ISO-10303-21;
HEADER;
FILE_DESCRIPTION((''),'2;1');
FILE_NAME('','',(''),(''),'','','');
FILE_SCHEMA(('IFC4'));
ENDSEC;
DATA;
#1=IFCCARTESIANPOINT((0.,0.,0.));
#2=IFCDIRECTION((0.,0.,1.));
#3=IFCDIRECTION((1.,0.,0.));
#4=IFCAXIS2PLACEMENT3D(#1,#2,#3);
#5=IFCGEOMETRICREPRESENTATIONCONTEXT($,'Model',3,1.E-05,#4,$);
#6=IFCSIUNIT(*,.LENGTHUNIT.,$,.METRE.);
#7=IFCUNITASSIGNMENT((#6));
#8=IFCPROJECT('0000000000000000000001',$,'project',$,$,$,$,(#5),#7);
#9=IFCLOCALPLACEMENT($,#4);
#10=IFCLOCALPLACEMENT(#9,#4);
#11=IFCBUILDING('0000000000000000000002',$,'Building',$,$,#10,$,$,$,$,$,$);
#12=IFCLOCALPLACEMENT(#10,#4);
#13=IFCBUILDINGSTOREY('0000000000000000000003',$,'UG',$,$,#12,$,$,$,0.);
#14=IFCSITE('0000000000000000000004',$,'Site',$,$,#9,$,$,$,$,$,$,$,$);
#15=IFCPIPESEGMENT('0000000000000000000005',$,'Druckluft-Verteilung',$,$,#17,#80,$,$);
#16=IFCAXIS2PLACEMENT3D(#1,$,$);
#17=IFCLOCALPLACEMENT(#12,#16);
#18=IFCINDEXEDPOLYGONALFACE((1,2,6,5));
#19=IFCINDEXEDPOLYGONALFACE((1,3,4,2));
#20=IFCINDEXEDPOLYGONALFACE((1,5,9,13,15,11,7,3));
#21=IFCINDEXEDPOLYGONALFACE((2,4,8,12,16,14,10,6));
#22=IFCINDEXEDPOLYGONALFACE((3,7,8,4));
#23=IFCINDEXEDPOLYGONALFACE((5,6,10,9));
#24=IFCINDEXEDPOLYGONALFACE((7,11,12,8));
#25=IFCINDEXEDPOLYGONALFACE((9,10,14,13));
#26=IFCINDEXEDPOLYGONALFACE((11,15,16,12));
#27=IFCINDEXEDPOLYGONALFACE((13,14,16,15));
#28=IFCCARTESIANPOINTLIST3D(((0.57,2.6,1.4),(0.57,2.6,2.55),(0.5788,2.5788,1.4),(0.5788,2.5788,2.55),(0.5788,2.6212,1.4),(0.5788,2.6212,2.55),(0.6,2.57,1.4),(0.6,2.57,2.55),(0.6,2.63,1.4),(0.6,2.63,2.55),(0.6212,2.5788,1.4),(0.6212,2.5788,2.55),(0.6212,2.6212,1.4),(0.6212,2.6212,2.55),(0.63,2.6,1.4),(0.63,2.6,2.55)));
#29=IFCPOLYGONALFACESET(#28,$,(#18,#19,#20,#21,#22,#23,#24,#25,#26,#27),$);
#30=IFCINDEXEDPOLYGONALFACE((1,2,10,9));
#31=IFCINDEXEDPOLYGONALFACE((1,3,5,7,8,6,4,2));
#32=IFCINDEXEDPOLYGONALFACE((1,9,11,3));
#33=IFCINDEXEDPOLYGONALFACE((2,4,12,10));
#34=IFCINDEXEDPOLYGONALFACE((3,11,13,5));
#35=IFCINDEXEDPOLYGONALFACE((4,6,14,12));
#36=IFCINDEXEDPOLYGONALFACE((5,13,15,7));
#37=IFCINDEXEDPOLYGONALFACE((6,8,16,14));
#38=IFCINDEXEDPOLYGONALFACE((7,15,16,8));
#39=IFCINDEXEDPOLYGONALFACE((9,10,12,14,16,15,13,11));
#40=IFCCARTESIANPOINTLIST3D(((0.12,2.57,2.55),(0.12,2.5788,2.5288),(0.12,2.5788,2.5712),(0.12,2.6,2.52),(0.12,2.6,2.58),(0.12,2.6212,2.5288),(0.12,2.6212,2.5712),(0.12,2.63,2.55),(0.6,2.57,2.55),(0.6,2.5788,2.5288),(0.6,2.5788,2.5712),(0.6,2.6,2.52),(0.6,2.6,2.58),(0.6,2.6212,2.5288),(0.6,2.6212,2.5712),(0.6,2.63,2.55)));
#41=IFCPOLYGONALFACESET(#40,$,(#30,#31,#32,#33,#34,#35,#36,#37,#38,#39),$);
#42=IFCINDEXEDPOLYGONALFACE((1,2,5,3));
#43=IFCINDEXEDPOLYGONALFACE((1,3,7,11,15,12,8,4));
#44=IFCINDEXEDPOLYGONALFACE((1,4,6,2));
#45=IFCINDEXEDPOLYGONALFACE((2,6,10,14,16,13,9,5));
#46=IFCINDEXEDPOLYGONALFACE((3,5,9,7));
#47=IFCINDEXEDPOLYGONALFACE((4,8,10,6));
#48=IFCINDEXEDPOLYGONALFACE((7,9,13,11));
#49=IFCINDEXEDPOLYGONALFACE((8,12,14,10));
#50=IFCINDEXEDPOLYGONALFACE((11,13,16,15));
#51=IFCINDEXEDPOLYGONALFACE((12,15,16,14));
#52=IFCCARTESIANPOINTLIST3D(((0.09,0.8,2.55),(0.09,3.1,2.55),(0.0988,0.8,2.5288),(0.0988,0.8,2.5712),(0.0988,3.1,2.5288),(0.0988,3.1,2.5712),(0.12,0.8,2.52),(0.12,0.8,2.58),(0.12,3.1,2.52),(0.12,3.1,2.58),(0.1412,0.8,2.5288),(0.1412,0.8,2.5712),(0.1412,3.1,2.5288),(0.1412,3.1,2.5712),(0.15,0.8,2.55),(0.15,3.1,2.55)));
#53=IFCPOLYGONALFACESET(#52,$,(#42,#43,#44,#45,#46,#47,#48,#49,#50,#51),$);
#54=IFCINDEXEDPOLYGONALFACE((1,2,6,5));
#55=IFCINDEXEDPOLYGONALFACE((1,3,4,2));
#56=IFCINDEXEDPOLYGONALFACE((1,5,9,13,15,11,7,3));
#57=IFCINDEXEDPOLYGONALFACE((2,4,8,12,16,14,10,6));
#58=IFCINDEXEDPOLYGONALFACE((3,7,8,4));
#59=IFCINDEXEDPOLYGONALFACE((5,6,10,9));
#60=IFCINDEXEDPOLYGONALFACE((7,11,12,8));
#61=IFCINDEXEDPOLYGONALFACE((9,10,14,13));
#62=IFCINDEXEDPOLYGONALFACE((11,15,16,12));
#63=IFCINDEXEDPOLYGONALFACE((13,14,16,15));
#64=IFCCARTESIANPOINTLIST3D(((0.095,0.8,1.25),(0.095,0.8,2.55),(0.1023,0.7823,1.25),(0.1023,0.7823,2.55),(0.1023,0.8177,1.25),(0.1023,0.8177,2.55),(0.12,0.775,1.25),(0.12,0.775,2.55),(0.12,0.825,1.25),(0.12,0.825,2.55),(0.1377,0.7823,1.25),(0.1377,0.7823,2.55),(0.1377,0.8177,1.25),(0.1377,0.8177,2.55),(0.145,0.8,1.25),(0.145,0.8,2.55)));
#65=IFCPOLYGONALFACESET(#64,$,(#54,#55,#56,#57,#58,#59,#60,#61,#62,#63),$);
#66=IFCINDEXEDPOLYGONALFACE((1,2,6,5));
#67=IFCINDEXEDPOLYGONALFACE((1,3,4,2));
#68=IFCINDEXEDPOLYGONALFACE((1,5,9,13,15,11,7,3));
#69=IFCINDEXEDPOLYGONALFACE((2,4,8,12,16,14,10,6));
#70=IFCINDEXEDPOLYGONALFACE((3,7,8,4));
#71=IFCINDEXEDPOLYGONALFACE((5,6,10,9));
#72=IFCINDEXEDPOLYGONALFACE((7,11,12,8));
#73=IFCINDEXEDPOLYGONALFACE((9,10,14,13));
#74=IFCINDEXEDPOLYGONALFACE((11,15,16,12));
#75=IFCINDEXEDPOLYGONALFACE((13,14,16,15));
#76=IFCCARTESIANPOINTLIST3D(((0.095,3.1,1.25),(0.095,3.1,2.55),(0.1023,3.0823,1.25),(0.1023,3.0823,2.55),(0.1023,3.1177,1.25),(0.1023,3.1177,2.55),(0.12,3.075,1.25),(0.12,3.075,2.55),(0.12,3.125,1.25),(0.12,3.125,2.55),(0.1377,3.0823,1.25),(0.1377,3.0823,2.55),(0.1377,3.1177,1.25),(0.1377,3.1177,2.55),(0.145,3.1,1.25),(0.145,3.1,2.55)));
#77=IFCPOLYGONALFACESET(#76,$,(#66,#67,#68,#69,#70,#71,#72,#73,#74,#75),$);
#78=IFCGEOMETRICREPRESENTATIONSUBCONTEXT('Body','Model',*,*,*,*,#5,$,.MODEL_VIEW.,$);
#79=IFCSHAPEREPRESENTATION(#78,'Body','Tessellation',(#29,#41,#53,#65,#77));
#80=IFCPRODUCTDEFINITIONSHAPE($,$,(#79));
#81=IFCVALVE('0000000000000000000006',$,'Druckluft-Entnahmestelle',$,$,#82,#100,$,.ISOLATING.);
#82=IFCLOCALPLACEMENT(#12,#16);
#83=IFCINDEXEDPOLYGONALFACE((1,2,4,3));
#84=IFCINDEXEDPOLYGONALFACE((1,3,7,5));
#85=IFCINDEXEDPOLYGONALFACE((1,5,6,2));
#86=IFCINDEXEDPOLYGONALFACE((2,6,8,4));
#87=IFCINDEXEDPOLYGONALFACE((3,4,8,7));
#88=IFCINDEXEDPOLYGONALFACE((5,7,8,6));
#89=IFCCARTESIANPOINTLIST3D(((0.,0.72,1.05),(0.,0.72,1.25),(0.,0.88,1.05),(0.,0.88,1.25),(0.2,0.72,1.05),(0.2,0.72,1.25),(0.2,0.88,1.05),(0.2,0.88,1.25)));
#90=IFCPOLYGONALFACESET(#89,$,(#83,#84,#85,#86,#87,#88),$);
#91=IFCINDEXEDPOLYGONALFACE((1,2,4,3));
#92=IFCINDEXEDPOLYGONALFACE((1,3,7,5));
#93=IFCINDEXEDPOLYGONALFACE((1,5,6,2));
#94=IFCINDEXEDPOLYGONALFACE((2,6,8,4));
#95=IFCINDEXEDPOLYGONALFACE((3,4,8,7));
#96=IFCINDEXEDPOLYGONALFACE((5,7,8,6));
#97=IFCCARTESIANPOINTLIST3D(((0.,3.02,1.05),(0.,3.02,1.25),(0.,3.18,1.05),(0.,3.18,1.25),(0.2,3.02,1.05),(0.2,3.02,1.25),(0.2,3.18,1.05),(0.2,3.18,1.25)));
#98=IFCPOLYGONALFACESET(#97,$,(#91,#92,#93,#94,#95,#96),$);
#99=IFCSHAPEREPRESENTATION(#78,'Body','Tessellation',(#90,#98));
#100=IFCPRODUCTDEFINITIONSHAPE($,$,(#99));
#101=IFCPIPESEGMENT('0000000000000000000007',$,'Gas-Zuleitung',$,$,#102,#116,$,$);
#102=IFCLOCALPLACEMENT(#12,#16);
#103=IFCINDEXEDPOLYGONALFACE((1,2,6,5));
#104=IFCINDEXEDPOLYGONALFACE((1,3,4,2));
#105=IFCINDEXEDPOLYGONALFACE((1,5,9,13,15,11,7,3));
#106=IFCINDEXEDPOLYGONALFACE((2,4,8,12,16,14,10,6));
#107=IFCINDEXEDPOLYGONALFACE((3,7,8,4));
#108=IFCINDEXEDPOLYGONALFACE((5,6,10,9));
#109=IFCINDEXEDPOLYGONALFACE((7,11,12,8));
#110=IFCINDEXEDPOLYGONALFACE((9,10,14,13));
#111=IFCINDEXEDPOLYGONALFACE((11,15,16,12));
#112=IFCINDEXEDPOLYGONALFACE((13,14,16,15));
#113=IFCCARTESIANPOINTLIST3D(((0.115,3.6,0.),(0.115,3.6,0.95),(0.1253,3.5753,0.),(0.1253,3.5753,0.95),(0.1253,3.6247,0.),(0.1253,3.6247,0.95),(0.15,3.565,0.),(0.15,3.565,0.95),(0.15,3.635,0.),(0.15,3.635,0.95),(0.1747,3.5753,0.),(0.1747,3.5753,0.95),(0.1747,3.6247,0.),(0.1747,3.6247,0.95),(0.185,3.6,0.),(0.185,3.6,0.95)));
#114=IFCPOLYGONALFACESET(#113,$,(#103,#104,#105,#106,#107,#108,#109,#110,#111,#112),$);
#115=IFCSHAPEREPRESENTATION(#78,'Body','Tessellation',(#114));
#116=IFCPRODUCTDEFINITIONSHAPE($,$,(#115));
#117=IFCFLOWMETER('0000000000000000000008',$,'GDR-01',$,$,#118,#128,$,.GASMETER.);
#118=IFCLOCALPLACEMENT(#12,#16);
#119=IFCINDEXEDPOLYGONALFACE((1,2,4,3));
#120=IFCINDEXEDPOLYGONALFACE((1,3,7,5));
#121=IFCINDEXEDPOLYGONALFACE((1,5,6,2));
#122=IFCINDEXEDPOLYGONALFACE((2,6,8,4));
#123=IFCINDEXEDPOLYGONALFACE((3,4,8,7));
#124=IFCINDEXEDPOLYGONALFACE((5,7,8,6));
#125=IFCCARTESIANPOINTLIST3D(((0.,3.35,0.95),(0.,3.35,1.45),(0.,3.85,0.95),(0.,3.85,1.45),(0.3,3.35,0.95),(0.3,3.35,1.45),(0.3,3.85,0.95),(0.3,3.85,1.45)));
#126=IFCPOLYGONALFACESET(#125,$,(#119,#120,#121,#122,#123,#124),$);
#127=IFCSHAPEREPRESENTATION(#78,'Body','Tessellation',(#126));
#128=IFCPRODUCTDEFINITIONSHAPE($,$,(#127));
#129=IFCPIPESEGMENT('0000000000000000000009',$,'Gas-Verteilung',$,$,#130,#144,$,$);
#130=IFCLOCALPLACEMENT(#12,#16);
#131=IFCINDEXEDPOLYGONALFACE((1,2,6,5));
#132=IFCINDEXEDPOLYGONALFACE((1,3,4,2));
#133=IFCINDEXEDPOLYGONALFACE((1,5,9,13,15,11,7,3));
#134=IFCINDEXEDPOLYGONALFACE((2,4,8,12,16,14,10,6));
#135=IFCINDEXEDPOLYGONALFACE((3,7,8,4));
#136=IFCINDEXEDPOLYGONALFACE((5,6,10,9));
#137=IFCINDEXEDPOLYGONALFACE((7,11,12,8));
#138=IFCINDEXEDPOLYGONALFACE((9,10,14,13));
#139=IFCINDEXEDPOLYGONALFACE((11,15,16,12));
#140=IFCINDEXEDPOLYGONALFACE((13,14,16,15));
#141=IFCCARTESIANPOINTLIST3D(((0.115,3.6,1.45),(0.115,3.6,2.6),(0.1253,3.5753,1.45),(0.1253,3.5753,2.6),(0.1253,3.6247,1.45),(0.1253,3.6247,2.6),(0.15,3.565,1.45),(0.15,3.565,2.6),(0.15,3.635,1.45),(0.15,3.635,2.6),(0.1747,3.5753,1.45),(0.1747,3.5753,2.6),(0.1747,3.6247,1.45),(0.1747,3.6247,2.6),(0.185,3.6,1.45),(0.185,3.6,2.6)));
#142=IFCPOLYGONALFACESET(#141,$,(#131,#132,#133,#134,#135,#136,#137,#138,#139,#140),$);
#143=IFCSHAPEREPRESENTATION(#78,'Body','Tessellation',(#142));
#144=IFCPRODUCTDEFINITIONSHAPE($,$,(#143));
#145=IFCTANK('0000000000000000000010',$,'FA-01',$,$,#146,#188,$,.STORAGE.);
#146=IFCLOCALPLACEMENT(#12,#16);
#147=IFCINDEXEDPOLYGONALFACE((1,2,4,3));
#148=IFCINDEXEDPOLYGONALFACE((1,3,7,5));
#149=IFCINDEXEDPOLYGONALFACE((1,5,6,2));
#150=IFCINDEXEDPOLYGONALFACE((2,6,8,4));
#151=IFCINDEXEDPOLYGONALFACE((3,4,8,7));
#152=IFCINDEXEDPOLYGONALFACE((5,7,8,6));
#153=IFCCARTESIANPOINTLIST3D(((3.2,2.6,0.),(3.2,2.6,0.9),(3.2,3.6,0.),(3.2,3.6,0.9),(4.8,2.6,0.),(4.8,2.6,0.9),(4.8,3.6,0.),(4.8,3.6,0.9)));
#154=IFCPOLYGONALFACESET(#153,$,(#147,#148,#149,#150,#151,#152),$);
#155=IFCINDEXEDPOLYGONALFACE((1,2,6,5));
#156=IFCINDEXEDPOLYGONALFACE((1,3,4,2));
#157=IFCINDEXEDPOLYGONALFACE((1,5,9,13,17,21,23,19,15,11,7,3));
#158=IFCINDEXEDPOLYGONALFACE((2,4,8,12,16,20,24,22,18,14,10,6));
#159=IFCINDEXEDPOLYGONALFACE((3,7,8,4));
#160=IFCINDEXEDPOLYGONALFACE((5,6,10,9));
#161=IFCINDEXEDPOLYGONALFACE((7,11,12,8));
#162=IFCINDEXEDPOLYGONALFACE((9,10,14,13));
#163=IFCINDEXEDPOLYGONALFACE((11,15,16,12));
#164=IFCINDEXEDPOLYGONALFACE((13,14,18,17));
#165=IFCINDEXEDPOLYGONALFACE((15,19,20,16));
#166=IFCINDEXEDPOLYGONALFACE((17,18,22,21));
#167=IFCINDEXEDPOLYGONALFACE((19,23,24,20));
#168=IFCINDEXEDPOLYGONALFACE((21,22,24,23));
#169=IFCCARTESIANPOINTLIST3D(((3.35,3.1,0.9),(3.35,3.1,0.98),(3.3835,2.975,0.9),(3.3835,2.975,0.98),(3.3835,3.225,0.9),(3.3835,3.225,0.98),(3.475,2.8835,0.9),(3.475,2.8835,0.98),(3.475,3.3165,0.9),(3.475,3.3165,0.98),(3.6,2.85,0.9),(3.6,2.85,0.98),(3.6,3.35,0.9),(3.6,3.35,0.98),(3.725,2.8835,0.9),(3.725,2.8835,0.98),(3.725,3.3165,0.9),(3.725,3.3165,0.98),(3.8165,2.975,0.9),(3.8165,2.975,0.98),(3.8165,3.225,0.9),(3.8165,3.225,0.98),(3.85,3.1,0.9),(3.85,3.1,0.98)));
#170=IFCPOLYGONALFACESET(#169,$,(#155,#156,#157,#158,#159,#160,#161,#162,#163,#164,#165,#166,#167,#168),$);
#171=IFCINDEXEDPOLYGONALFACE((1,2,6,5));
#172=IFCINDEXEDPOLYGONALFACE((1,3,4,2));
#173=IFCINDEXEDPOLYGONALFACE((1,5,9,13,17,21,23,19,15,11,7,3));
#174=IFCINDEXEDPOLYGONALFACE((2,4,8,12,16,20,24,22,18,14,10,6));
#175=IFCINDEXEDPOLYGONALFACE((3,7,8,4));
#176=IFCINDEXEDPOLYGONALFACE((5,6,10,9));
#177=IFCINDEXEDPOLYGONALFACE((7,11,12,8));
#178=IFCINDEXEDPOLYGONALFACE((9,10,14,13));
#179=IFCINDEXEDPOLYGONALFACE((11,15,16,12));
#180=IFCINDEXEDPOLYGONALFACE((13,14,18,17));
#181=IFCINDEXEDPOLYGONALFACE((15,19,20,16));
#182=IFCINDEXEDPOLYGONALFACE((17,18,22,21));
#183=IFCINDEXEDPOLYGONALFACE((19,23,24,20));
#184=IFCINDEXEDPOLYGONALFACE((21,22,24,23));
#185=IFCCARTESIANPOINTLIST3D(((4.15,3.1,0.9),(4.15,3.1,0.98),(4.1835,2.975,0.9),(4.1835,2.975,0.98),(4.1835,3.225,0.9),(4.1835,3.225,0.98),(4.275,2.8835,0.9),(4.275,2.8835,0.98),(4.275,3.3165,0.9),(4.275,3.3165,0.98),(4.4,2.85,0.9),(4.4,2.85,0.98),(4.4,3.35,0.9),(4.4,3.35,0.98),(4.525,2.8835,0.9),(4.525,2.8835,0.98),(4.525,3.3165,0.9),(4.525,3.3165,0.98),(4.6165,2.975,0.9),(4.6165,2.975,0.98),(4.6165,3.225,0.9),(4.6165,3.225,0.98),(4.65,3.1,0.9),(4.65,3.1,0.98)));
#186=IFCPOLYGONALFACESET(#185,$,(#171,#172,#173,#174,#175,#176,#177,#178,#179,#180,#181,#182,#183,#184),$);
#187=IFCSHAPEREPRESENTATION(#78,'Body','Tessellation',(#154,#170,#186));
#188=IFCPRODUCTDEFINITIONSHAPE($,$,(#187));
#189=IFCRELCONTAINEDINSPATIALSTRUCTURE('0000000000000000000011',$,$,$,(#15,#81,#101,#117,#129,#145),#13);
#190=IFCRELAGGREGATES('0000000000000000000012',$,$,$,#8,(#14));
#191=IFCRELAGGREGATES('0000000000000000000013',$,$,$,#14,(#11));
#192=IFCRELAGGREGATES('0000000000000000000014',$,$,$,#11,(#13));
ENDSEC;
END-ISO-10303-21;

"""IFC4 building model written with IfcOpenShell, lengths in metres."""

from ifc_helpers import new_model, si_unit, frame, origin_with_axes, place, context, subcontext, project, spatial, polyline, outline, extrude, element, save


model = new_model("IFC4")

# Units and contexts
model_context = context("Model", 3, precision=1e-05, world=origin_with_axes())
body_context = subcontext(model_context, "Body", "Model", "MODEL_VIEW")
ifc_project = project(units=[si_unit("LENGTHUNIT", "METRE")], contexts=[model_context])

# Site, building, storey
site_placement = place(None, origin_with_axes())
site = spatial("IfcSite", under=ifc_project, at=site_placement, Name="Site")
building_placement = place(site_placement, origin_with_axes())
building = spatial("IfcBuilding", under=site, at=building_placement, Name="Building")
storey_placement = place(building_placement, origin_with_axes())
storey = spatial("IfcBuildingStorey", under=building, at=storey_placement, Name="UG", Elevation=0.0)

# Pipe segment
pipe_segment_1_placement = place(storey_placement, origin_with_axes())
element("IfcPipeSegment", 1, at=pipe_segment_1_placement, inside=storey, Name="Druckluft-Verteilung", context=body_context, shape_type="SweptSolid", body=[
    extrude(outline(polyline([(0.03, 0.0, 0.0), (0.0212, 0.0212, 0.0), (0.0, 0.03, 0.0), (-0.0212, 0.0212, 0.0), (-0.03, 0.0, 0.0), (-0.0212, -0.0212, 0.0), (0.0, -0.03, 0.0), (0.0212, -0.0212, 0.0), (0.03, 0.0, 0.0)])), frame((0.6, 2.6, 1.4), z_axis=(0.0, 0.0, 1.0), x_axis=(1.0, 0.0, 0.0)), (0.0, 0.0, 1.0), 1.15),
    extrude(outline(polyline([(0.03, 0.0, 0.0), (0.0212, 0.0212, 0.0), (0.0, 0.03, 0.0), (-0.0212, 0.0212, 0.0), (-0.03, 0.0, 0.0), (-0.0212, -0.0212, 0.0), (0.0, -0.03, 0.0), (0.0212, -0.0212, 0.0), (0.03, 0.0, 0.0)])), frame((0.6, 2.6, 2.55), z_axis=(-1.0, 0.0, 0.0), x_axis=(0.0, -1.0, 0.0)), (0.0, 0.0, 1.0), 0.48),
    extrude(outline(polyline([(0.03, 0.0, 0.0), (0.0212, 0.0212, 0.0), (0.0, 0.03, 0.0), (-0.0212, 0.0212, 0.0), (-0.03, 0.0, 0.0), (-0.0212, -0.0212, 0.0), (0.0, -0.03, 0.0), (0.0212, -0.0212, 0.0), (0.03, 0.0, 0.0)])), frame((0.12, 0.8, 2.55), z_axis=(0.0, 1.0, 0.0), x_axis=(-1.0, 0.0, 0.0)), (0.0, 0.0, 1.0), 2.3),
    extrude(outline(polyline([(0.025, 0.0, 0.0), (0.0177, 0.0177, 0.0), (0.0, 0.025, 0.0), (-0.0177, 0.0177, 0.0), (-0.025, 0.0, 0.0), (-0.0177, -0.0177, 0.0), (0.0, -0.025, 0.0), (0.0177, -0.0177, 0.0), (0.025, 0.0, 0.0)])), frame((0.12, 0.8, 2.55), z_axis=(0.0, 0.0, -1.0), x_axis=(1.0, 0.0, 0.0)), (0.0, 0.0, 1.0), 1.3),
    extrude(outline(polyline([(0.025, 0.0, 0.0), (0.0177, 0.0177, 0.0), (0.0, 0.025, 0.0), (-0.0177, 0.0177, 0.0), (-0.025, 0.0, 0.0), (-0.0177, -0.0177, 0.0), (0.0, -0.025, 0.0), (0.0177, -0.0177, 0.0), (0.025, 0.0, 0.0)])), frame((0.12, 3.1, 2.55), z_axis=(0.0, 0.0, -1.0), x_axis=(1.0, 0.0, 0.0)), (0.0, 0.0, 1.0), 1.3),
])

# Valve
valve_placement = place(storey_placement, origin_with_axes())
element("IfcValve", 2, at=valve_placement, inside=storey, Name="Druckluft-Entnahmestelle", PredefinedType="ISOLATING", context=body_context, shape_type="SweptSolid", body=[
    extrude(outline(polyline([(0.0, 0.72, 0.0), (0.2, 0.72, 0.0), (0.2, 0.88, 0.0), (0.0, 0.88, 0.0), (0.0, 0.72, 0.0)])), frame((0.0, 0.0, 1.05), z_axis=(0.0, 0.0, 1.0), x_axis=(1.0, 0.0, 0.0)), (0.0, 0.0, 1.0), 0.2),
    extrude(outline(polyline([(0.0, 3.02, 0.0), (0.2, 3.02, 0.0), (0.2, 3.18, 0.0), (0.0, 3.18, 0.0), (0.0, 3.02, 0.0)])), frame((0.0, 0.0, 1.05), z_axis=(0.0, 0.0, 1.0), x_axis=(1.0, 0.0, 0.0)), (0.0, 0.0, 1.0), 0.2),
])

# Pipe segment
pipe_segment_2_placement = place(storey_placement, origin_with_axes())
element("IfcPipeSegment", 3, at=pipe_segment_2_placement, inside=storey, Name="Gas-Zuleitung", context=body_context, shape_type="SweptSolid", body=[
    extrude(outline(polyline([(0.035, 0.0, 0.0), (0.0247, 0.0247, 0.0), (0.0, 0.035, 0.0), (-0.0247, 0.0247, 0.0), (-0.035, 0.0, 0.0), (-0.0247, -0.0247, 0.0), (0.0, -0.035, 0.0), (0.0247, -0.0247, 0.0), (0.035, 0.0, 0.0)])), frame((0.15, 3.6, 0.0), z_axis=(0.0, 0.0, 1.0), x_axis=(1.0, 0.0, 0.0)), (0.0, 0.0, 1.0), 0.95),
])

# Flow meter
flow_meter_placement = place(storey_placement, origin_with_axes())
element("IfcFlowMeter", 4, at=flow_meter_placement, inside=storey, Name="GDR-01", PredefinedType="GASMETER", context=body_context, shape_type="SweptSolid", body=[
    extrude(outline(polyline([(0.0, 3.35, 0.0), (0.3, 3.35, 0.0), (0.3, 3.85, 0.0), (0.0, 3.85, 0.0), (0.0, 3.35, 0.0)])), frame((0.0, 0.0, 0.95), z_axis=(0.0, 0.0, 1.0), x_axis=(1.0, 0.0, 0.0)), (0.0, 0.0, 1.0), 0.5),
])

# Pipe segment
pipe_segment_3_placement = place(storey_placement, origin_with_axes())
element("IfcPipeSegment", 5, at=pipe_segment_3_placement, inside=storey, Name="Gas-Verteilung", context=body_context, shape_type="SweptSolid", body=[
    extrude(outline(polyline([(0.035, 0.0, 0.0), (0.0247, 0.0247, 0.0), (0.0, 0.035, 0.0), (-0.0247, 0.0247, 0.0), (-0.035, 0.0, 0.0), (-0.0247, -0.0247, 0.0), (0.0, -0.035, 0.0), (0.0247, -0.0247, 0.0), (0.035, 0.0, 0.0)])), frame((0.15, 3.6, 1.45), z_axis=(0.0, 0.0, 1.0), x_axis=(1.0, 0.0, 0.0)), (0.0, 0.0, 1.0), 1.15),
])

# Tank
tank_1_placement = place(storey_placement, origin_with_axes())
element("IfcTank", 6, at=tank_1_placement, inside=storey, Name="FA-01", PredefinedType="STORAGE", context=body_context, shape_type="SweptSolid", body=[
    extrude(outline(polyline([(3.2, 2.6, 0.0), (4.8, 2.6, 0.0), (4.8, 3.6, 0.0), (3.2, 3.6, 0.0), (3.2, 2.6, 0.0)])), origin_with_axes(), (0.0, 0.0, 1.0), 0.9),
    extrude(outline(polyline([(0.25, 0.0, 0.0), (0.2165, 0.125, 0.0), (0.125, 0.2165, 0.0), (0.0, 0.25, 0.0), (-0.125, 0.2165, 0.0), (-0.2165, 0.125, 0.0), (-0.25, 0.0, 0.0), (-0.2165, -0.125, 0.0), (-0.125, -0.2165, 0.0), (0.0, -0.25, 0.0), (0.125, -0.2165, 0.0), (0.2165, -0.125, 0.0), (0.25, 0.0, 0.0)])), frame((3.6, 3.1, 0.9), z_axis=(0.0, 0.0, 1.0), x_axis=(1.0, 0.0, 0.0)), (0.0, 0.0, 1.0), 0.08),
    extrude(outline(polyline([(0.25, 0.0, 0.0), (0.2165, 0.125, 0.0), (0.125, 0.2165, 0.0), (0.0, 0.25, 0.0), (-0.125, 0.2165, 0.0), (-0.2165, 0.125, 0.0), (-0.25, 0.0, 0.0), (-0.2165, -0.125, 0.0), (-0.125, -0.2165, 0.0), (0.0, -0.25, 0.0), (0.125, -0.2165, 0.0), (0.2165, -0.125, 0.0), (0.25, 0.0, 0.0)])), frame((4.4, 3.1, 0.9), z_axis=(0.0, 0.0, 1.0), x_axis=(1.0, 0.0, 0.0)), (0.0, 0.0, 1.0), 0.08),
])

save(model, "model.ifc")
